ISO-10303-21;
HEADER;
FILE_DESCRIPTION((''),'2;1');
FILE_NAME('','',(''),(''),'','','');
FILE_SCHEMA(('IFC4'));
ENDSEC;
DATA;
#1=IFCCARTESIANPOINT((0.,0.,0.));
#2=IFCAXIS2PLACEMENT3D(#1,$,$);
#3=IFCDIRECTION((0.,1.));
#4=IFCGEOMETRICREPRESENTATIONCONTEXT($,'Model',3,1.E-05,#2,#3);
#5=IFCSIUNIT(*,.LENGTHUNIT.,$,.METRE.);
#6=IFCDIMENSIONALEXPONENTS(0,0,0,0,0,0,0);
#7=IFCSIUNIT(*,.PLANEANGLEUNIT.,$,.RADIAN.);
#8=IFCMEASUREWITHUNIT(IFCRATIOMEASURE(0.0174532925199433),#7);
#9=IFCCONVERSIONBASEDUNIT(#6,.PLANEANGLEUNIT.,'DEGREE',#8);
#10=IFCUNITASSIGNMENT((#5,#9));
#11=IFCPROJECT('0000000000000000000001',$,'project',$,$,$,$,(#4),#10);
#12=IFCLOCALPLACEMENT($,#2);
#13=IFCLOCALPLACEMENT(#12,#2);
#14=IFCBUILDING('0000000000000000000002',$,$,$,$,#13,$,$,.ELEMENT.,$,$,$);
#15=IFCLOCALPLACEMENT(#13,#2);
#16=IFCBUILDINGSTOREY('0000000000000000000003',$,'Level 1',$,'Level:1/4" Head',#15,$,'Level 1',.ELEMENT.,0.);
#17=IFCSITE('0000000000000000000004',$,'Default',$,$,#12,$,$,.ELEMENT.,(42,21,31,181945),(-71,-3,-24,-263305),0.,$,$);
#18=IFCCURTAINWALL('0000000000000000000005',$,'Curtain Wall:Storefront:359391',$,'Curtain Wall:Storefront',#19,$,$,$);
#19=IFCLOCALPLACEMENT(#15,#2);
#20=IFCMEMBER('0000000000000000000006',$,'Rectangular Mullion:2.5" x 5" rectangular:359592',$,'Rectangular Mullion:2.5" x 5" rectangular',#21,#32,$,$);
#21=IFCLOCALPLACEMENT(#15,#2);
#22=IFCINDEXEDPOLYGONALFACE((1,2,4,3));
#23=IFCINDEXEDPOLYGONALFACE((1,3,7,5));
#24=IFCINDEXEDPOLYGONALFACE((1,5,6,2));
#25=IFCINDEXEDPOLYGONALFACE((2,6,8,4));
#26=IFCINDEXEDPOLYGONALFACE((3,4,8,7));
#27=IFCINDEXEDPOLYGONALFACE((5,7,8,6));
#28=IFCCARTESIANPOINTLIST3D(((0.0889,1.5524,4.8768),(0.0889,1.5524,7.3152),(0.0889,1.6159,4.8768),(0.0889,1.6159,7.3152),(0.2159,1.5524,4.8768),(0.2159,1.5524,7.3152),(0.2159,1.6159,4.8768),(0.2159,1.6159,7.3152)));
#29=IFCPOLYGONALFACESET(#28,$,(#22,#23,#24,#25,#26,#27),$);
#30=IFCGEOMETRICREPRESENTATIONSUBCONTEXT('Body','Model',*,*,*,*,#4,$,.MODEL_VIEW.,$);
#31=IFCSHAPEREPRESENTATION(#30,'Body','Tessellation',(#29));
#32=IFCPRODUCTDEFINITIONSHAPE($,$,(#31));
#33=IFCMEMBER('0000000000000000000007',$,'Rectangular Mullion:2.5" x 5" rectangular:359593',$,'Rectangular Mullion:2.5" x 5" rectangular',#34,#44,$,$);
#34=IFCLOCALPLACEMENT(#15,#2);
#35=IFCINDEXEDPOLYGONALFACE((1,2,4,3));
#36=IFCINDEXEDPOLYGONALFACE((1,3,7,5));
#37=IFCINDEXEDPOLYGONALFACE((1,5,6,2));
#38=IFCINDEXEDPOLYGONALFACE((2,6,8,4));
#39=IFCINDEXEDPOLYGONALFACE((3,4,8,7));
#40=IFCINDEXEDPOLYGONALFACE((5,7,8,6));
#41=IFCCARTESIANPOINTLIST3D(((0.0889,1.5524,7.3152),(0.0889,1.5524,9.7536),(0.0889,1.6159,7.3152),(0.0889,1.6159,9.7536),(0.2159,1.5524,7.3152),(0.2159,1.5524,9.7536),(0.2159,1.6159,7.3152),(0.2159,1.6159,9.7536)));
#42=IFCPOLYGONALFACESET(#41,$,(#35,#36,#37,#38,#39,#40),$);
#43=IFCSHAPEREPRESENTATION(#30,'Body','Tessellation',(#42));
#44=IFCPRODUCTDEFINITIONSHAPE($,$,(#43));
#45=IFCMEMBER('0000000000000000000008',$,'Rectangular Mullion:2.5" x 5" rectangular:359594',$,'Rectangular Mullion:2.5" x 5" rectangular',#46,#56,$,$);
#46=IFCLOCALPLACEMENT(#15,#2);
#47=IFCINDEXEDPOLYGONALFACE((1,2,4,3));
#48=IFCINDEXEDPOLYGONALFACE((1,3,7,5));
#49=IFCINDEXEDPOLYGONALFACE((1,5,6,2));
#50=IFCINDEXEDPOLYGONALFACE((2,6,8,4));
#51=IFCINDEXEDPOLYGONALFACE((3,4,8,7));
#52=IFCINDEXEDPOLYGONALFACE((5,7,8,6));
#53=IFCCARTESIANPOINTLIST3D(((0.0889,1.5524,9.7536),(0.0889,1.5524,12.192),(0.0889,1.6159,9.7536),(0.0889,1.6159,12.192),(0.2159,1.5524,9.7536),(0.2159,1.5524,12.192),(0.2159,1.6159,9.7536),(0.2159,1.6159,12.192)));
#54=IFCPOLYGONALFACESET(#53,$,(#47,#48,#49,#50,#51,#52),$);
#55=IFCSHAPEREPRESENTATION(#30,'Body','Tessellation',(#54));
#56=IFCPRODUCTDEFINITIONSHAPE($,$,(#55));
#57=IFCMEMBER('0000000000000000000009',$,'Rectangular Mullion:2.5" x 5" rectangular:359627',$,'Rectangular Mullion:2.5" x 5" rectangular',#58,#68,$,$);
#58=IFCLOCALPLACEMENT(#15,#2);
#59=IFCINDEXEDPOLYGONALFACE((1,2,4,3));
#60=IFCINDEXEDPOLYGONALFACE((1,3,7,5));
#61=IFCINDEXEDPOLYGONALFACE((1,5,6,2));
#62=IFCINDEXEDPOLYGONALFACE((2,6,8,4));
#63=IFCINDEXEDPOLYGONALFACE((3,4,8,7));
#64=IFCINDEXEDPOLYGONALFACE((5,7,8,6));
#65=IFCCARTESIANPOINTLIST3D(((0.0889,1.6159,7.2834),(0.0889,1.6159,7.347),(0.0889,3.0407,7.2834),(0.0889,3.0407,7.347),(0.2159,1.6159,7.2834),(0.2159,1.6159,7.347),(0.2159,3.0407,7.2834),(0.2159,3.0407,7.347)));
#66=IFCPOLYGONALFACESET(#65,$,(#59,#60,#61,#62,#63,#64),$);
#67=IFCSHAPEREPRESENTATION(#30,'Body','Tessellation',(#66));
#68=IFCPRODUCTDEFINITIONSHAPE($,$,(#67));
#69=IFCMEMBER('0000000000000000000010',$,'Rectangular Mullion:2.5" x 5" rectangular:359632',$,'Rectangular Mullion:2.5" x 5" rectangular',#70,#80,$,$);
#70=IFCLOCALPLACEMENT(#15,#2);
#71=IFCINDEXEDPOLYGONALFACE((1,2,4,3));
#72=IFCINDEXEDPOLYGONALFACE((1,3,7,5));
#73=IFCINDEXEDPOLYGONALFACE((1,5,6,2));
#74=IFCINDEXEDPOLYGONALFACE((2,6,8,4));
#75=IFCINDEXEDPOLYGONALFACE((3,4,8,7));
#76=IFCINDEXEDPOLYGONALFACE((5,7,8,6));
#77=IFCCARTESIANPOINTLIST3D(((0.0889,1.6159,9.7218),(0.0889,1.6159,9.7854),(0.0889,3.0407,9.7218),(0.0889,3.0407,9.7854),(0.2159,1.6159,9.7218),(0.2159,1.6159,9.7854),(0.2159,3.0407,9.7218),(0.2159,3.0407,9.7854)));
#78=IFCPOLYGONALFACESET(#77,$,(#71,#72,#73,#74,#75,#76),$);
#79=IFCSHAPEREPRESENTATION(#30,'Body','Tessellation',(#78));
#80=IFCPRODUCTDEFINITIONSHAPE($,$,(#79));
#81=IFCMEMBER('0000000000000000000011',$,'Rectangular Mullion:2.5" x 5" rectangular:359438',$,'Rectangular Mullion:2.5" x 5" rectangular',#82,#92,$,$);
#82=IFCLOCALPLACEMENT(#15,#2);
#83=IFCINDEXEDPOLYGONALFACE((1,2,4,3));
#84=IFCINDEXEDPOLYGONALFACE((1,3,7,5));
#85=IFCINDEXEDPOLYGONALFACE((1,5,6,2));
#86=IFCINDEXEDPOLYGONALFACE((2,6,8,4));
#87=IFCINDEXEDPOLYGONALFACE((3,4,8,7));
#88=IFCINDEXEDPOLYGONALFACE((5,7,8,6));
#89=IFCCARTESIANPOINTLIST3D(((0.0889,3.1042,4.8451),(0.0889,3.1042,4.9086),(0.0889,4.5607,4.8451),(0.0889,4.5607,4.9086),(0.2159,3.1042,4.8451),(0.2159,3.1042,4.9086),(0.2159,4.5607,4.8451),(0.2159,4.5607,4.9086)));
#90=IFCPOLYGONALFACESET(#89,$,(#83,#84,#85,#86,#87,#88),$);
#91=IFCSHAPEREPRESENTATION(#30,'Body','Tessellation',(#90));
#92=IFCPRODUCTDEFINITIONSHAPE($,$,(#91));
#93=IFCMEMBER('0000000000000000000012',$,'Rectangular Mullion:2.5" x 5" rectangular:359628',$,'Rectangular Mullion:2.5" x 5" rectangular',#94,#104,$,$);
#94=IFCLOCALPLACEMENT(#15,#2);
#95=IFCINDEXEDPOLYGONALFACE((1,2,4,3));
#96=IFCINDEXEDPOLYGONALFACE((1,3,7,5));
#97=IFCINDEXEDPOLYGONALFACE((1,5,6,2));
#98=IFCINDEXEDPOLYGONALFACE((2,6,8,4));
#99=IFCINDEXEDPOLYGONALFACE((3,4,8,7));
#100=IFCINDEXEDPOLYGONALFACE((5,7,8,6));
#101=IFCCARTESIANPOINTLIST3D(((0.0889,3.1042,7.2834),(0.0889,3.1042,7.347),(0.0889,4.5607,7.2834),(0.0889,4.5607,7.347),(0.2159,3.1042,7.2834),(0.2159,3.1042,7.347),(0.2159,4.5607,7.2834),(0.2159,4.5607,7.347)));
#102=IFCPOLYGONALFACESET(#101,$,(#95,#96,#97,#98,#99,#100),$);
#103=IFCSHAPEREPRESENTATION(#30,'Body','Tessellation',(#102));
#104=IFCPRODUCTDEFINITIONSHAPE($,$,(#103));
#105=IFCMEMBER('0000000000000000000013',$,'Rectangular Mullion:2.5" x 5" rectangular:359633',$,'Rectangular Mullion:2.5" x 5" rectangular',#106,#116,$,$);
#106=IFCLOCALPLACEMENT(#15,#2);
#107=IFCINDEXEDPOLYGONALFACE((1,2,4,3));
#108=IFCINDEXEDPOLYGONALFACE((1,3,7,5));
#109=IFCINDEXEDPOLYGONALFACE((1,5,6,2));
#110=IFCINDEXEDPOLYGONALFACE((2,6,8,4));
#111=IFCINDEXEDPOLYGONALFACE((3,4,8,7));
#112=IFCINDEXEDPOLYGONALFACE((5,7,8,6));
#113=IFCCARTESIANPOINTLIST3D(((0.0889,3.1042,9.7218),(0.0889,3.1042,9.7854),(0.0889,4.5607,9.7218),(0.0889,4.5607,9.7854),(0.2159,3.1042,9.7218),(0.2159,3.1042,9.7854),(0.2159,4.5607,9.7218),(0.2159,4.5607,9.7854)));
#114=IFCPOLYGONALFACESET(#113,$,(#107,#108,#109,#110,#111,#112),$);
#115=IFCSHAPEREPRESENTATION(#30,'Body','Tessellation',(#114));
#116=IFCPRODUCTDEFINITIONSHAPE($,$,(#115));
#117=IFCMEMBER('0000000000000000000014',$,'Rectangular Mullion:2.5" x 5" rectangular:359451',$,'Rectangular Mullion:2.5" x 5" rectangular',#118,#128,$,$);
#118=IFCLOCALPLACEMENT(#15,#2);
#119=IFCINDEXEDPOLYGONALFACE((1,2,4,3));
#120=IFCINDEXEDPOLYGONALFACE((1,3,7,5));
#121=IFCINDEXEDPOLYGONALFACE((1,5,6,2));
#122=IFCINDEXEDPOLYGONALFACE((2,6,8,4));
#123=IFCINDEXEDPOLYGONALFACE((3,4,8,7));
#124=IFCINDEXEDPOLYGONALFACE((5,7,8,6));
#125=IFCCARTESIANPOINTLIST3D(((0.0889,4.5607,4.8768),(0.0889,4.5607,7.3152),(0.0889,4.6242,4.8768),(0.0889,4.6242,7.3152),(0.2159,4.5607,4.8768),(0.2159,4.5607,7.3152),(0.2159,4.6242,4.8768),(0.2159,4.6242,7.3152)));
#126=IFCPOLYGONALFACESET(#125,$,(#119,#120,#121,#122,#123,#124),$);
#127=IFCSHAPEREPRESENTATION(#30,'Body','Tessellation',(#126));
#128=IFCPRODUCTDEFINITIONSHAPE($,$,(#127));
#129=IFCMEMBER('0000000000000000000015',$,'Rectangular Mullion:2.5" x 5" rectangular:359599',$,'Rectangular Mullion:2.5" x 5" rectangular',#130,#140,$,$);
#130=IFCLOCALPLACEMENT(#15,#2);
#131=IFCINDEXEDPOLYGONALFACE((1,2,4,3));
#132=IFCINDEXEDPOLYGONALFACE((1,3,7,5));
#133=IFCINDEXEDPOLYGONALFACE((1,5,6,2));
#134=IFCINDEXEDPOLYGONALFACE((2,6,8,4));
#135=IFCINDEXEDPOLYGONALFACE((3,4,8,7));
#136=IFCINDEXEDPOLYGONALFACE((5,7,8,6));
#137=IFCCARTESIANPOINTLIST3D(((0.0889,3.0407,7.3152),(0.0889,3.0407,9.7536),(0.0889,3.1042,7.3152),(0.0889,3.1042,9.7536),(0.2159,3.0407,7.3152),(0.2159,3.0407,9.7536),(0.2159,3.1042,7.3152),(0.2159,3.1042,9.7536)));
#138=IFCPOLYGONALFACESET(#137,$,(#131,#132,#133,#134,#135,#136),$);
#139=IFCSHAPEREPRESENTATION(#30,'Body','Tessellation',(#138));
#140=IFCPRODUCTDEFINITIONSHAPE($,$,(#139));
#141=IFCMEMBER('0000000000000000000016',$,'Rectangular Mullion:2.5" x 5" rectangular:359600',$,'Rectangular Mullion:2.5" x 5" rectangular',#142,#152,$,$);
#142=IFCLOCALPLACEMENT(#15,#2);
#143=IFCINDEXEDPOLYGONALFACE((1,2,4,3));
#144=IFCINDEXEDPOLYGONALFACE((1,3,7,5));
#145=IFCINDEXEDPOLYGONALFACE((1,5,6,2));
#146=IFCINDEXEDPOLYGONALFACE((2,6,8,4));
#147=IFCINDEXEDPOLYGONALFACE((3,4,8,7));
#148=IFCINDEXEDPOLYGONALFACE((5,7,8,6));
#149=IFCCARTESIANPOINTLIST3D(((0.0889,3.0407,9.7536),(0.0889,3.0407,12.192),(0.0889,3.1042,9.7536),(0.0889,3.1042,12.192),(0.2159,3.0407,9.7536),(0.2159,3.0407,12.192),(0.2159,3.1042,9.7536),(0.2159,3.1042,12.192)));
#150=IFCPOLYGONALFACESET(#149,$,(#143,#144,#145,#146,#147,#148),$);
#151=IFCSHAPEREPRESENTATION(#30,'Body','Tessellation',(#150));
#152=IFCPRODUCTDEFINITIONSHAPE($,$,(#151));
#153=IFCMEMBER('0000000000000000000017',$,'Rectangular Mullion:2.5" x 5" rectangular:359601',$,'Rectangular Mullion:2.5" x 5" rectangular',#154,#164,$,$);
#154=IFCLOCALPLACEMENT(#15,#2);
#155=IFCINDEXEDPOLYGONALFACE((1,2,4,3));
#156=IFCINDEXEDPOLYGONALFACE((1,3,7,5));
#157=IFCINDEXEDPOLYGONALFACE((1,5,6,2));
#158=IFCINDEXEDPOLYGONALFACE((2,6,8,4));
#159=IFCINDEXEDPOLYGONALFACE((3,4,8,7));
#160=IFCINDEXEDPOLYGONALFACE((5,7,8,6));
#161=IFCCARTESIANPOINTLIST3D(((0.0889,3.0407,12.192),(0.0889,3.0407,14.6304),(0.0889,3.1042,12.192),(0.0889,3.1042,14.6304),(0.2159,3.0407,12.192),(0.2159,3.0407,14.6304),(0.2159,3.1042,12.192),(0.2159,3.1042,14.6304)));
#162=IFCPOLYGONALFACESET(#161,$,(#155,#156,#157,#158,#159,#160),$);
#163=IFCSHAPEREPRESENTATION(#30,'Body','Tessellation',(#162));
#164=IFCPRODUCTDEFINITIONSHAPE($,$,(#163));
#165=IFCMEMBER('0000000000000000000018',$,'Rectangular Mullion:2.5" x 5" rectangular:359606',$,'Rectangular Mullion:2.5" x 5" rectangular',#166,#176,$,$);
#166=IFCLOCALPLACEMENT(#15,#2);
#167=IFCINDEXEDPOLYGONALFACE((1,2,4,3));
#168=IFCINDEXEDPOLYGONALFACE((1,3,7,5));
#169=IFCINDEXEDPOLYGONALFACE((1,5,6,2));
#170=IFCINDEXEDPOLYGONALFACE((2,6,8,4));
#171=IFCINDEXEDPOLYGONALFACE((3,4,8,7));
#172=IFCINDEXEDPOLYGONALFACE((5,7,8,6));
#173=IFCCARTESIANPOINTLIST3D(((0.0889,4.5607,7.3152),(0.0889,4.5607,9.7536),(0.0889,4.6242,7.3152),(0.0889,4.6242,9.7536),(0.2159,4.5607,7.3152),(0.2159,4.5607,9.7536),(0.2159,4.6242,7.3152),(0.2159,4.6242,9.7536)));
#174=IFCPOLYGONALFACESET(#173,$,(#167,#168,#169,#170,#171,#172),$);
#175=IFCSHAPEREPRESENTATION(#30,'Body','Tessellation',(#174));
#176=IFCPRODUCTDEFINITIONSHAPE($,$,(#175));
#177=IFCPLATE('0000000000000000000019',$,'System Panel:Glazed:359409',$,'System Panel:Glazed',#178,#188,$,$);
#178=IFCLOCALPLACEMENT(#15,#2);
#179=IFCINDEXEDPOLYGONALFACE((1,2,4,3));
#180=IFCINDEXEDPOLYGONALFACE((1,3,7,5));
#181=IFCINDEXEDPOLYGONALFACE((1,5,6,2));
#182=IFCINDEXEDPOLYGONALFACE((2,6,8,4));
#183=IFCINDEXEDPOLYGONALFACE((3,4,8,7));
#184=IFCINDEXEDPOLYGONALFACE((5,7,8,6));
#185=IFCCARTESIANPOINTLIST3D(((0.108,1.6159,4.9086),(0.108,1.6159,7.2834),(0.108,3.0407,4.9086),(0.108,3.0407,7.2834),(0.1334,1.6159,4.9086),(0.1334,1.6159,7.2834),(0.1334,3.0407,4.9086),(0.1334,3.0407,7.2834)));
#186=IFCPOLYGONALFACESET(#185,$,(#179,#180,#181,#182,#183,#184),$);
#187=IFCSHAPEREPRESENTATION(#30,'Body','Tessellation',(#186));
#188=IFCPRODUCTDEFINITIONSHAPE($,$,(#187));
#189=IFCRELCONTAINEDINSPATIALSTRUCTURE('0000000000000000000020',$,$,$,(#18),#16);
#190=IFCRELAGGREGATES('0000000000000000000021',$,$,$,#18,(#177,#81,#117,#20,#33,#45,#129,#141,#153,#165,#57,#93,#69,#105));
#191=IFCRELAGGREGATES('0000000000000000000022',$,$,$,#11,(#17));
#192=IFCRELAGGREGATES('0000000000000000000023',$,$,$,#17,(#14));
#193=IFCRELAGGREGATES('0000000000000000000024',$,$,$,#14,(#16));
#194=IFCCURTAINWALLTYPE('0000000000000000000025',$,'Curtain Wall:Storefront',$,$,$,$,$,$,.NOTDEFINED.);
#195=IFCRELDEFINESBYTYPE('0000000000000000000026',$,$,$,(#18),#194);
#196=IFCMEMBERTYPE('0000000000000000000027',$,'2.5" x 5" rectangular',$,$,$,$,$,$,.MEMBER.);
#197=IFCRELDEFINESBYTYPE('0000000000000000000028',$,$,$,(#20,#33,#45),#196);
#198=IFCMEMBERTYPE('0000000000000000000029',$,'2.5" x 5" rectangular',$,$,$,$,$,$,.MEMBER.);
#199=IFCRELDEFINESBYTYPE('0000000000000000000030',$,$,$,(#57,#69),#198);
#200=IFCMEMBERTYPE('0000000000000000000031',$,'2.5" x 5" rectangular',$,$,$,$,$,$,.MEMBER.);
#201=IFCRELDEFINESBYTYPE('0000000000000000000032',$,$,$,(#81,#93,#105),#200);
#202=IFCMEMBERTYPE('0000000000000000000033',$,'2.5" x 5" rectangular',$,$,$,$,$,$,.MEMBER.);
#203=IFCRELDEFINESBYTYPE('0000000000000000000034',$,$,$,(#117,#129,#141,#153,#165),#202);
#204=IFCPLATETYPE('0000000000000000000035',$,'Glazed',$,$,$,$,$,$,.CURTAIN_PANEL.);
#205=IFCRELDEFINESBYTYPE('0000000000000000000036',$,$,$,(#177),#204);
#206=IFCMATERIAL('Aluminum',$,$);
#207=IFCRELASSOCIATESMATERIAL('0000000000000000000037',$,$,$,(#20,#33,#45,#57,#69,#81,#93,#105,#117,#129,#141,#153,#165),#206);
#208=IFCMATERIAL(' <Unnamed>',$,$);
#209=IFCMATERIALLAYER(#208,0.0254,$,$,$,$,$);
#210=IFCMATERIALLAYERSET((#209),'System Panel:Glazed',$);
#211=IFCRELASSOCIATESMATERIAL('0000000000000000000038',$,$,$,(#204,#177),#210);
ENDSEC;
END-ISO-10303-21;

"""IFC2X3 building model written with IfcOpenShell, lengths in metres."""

from ifc_helpers import new_model, entity, si_unit, converted_unit, direction, frame, frame_2d, origin, origin_2d_with_axis, place, context, subcontext, project, spatial, rectangle, extrude, source, transform, mapped, material, layer, layer_set, layer_usage, type_object, type_shapes, element, aggregate, save


model = new_model("IFC2X3")

# Units and contexts
model_context = context("Model", 3, precision=1e-05, world=origin(), true_north=direction((0.0, 1.0)))
body_context = subcontext(model_context, "Body", "Model", "MODEL_VIEW")
ifc_project = project(units=[si_unit("LENGTHUNIT", "METRE"), converted_unit("PLANEANGLEUNIT", "DEGREE", entity("IfcRatioMeasure", 0.0174532925199433), si_unit("PLANEANGLEUNIT", "RADIAN"), dimensions=[0, 0, 0, 0, 0, 0, 0])], contexts=[model_context])

# Site, building, storey
site_placement = place(None, origin())
site = spatial("IfcSite", under=ifc_project, at=site_placement, Name="Default", CompositionType="ELEMENT", RefLatitude=(42, 21, 31, 181945), RefLongitude=(-71, -3, -24, -263305), RefElevation=0.0)
building_placement = place(site_placement, origin())
building = spatial("IfcBuilding", under=site, at=building_placement, CompositionType="ELEMENT")
storey_placement = place(building_placement, origin())
storey = spatial("IfcBuildingStorey", under=building, at=storey_placement, Name="Level 1", ObjectType="Level:1/4\" Head", LongName="Level 1", CompositionType="ELEMENT", Elevation=0.0)

# Curtain wall, members, plate
curtain_wall_type = type_object("IfcCurtainWallType", Name="Curtain Wall:Storefront", PredefinedType="NOTDEFINED")
curtain_wall_placement = place(storey_placement, origin())
curtain_wall = element("IfcCurtainWall", 1, at=curtain_wall_placement, inside=storey, type_object=curtain_wall_type, Name="Curtain Wall:Storefront:359391", ObjectType="Curtain Wall:Storefront")
ifc_material_1 = material(Name="Aluminum")
member_type_1 = type_object("IfcMemberType", Name="2.5\" x 5\" rectangular", PredefinedType="MEMBER")
shared_shape_1 = source(origin(), body_context, "Body", "SweptSolid", [
    extrude(rectangle(XDim=0.127, YDim=0.0635, at=origin_2d_with_axis()), frame((-0.0318, 0.0, -2.4384), z_axis=(0.0, 0.0, 1.0), x_axis=(0.0, -1.0, 0.0)), (0.0, 0.0, 1.0), 2.4384),
])
type_shapes(member_type_1, [shared_shape_1])
member_1_placement = place(storey_placement, frame((0.1524, 1.5524, 7.3152), z_axis=(0.0, 0.0, 1.0), x_axis=(0.0, -1.0, 0.0)))
member_1 = element("IfcMember", 2, at=member_1_placement, type_object=member_type_1, material=ifc_material_1, Name="Rectangular Mullion:2.5\" x 5\" rectangular:359592", ObjectType="Rectangular Mullion:2.5\" x 5\" rectangular", context=body_context, shape_type="MappedRepresentation", body=[
    mapped(shared_shape_1, transform((0.0, 0.0, 0.0), scale=1.0)),
])
member_2_placement = place(storey_placement, frame((0.1524, 1.5524, 9.7536), z_axis=(0.0, 0.0, 1.0), x_axis=(0.0, -1.0, 0.0)))
member_2 = element("IfcMember", 3, at=member_2_placement, type_object=member_type_1, material=ifc_material_1, Name="Rectangular Mullion:2.5\" x 5\" rectangular:359593", ObjectType="Rectangular Mullion:2.5\" x 5\" rectangular", context=body_context, shape_type="MappedRepresentation", body=[
    mapped(shared_shape_1, transform((0.0, 0.0, 0.0), scale=1.0)),
])
member_3_placement = place(storey_placement, frame((0.1524, 1.5524, 12.192), z_axis=(0.0, 0.0, 1.0), x_axis=(0.0, -1.0, 0.0)))
member_3 = element("IfcMember", 4, at=member_3_placement, type_object=member_type_1, material=ifc_material_1, Name="Rectangular Mullion:2.5\" x 5\" rectangular:359594", ObjectType="Rectangular Mullion:2.5\" x 5\" rectangular", context=body_context, shape_type="MappedRepresentation", body=[
    mapped(shared_shape_1, transform((0.0, 0.0, 0.0), scale=1.0)),
])
member_type_2 = type_object("IfcMemberType", Name="2.5\" x 5\" rectangular", PredefinedType="MEMBER")
shared_shape_2 = source(origin(), body_context, "Body", "SweptSolid", [
    extrude(rectangle(XDim=0.127, YDim=0.0635, at=origin_2d_with_axis()), frame((0.0, 0.0, -1.4248), z_axis=(0.0, 0.0, 1.0), x_axis=(0.0, -1.0, 0.0)), (0.0, 0.0, 1.0), 1.4248),
])
type_shapes(member_type_2, [shared_shape_2])
member_4_placement = place(storey_placement, frame((0.1524, 3.0407, 7.3152), z_axis=(0.0, 1.0, 0.0), x_axis=(0.0, 0.0, 1.0)))
member_4 = element("IfcMember", 5, at=member_4_placement, type_object=member_type_2, material=ifc_material_1, Name="Rectangular Mullion:2.5\" x 5\" rectangular:359627", ObjectType="Rectangular Mullion:2.5\" x 5\" rectangular", context=body_context, shape_type="MappedRepresentation", body=[
    mapped(shared_shape_2, transform((0.0, 0.0, 0.0), scale=1.0)),
])
member_5_placement = place(storey_placement, frame((0.1524, 3.0407, 9.7536), z_axis=(0.0, 1.0, 0.0), x_axis=(0.0, 0.0, 1.0)))
member_5 = element("IfcMember", 6, at=member_5_placement, type_object=member_type_2, material=ifc_material_1, Name="Rectangular Mullion:2.5\" x 5\" rectangular:359632", ObjectType="Rectangular Mullion:2.5\" x 5\" rectangular", context=body_context, shape_type="MappedRepresentation", body=[
    mapped(shared_shape_2, transform((0.0, 0.0, 0.0), scale=1.0)),
])
member_type_3 = type_object("IfcMemberType", Name="2.5\" x 5\" rectangular", PredefinedType="MEMBER")
shared_shape_3 = source(origin(), body_context, "Body", "SweptSolid", [
    extrude(rectangle(XDim=0.127, YDim=0.0635, at=origin_2d_with_axis()), frame((0.0, 0.0, -1.4565), z_axis=(0.0, 0.0, 1.0), x_axis=(0.0, -1.0, 0.0)), (0.0, 0.0, 1.0), 1.4565),
])
type_shapes(member_type_3, [shared_shape_3])
member_6_placement = place(storey_placement, frame((0.1524, 4.5607, 4.8768), z_axis=(0.0, 1.0, 0.0), x_axis=(0.0, 0.0, 1.0)))
member_6 = element("IfcMember", 7, at=member_6_placement, type_object=member_type_3, material=ifc_material_1, Name="Rectangular Mullion:2.5\" x 5\" rectangular:359438", ObjectType="Rectangular Mullion:2.5\" x 5\" rectangular", context=body_context, shape_type="MappedRepresentation", body=[
    mapped(shared_shape_3, transform((0.0, 0.0, 0.0), scale=1.0)),
])
member_7_placement = place(storey_placement, frame((0.1524, 4.5607, 7.3152), z_axis=(0.0, 1.0, 0.0), x_axis=(0.0, 0.0, 1.0)))
member_7 = element("IfcMember", 8, at=member_7_placement, type_object=member_type_3, material=ifc_material_1, Name="Rectangular Mullion:2.5\" x 5\" rectangular:359628", ObjectType="Rectangular Mullion:2.5\" x 5\" rectangular", context=body_context, shape_type="MappedRepresentation", body=[
    mapped(shared_shape_3, transform((0.0, 0.0, 0.0), scale=1.0)),
])
member_8_placement = place(storey_placement, frame((0.1524, 4.5607, 9.7536), z_axis=(0.0, 1.0, 0.0), x_axis=(0.0, 0.0, 1.0)))
member_8 = element("IfcMember", 9, at=member_8_placement, type_object=member_type_3, material=ifc_material_1, Name="Rectangular Mullion:2.5\" x 5\" rectangular:359633", ObjectType="Rectangular Mullion:2.5\" x 5\" rectangular", context=body_context, shape_type="MappedRepresentation", body=[
    mapped(shared_shape_3, transform((0.0, 0.0, 0.0), scale=1.0)),
])
member_type_4 = type_object("IfcMemberType", Name="2.5\" x 5\" rectangular", PredefinedType="MEMBER")
shared_shape_4 = source(origin(), body_context, "Body", "SweptSolid", [
    extrude(rectangle(XDim=0.127, YDim=0.0635, at=origin_2d_with_axis()), frame((0.0, 0.0, -2.4384), z_axis=(0.0, 0.0, 1.0), x_axis=(0.0, -1.0, 0.0)), (0.0, 0.0, 1.0), 2.4384),
])
type_shapes(member_type_4, [shared_shape_4])
member_9_placement = place(storey_placement, frame((0.1524, 4.5924, 4.8768), z_axis=(0.0, 0.0, -1.0), x_axis=(0.0, 1.0, 0.0)))
member_9 = element("IfcMember", 10, at=member_9_placement, type_object=member_type_4, material=ifc_material_1, Name="Rectangular Mullion:2.5\" x 5\" rectangular:359451", ObjectType="Rectangular Mullion:2.5\" x 5\" rectangular", context=body_context, shape_type="MappedRepresentation", body=[
    mapped(shared_shape_4, transform((0.0, 0.0, 0.0), scale=1.0)),
])
member_10_placement = place(storey_placement, frame((0.1524, 3.0724, 7.3152), z_axis=(0.0, 0.0, -1.0), x_axis=(0.0, 1.0, 0.0)))
member_10 = element("IfcMember", 11, at=member_10_placement, type_object=member_type_4, material=ifc_material_1, Name="Rectangular Mullion:2.5\" x 5\" rectangular:359599", ObjectType="Rectangular Mullion:2.5\" x 5\" rectangular", context=body_context, shape_type="MappedRepresentation", body=[
    mapped(shared_shape_4, transform((0.0, 0.0, 0.0), scale=1.0)),
])
member_11_placement = place(storey_placement, frame((0.1524, 3.0724, 9.7536), z_axis=(0.0, 0.0, -1.0), x_axis=(0.0, 1.0, 0.0)))
member_11 = element("IfcMember", 12, at=member_11_placement, type_object=member_type_4, material=ifc_material_1, Name="Rectangular Mullion:2.5\" x 5\" rectangular:359600", ObjectType="Rectangular Mullion:2.5\" x 5\" rectangular", context=body_context, shape_type="MappedRepresentation", body=[
    mapped(shared_shape_4, transform((0.0, 0.0, 0.0), scale=1.0)),
])
member_12_placement = place(storey_placement, frame((0.1524, 3.0724, 12.192), z_axis=(0.0, 0.0, -1.0), x_axis=(0.0, 1.0, 0.0)))
member_12 = element("IfcMember", 13, at=member_12_placement, type_object=member_type_4, material=ifc_material_1, Name="Rectangular Mullion:2.5\" x 5\" rectangular:359601", ObjectType="Rectangular Mullion:2.5\" x 5\" rectangular", context=body_context, shape_type="MappedRepresentation", body=[
    mapped(shared_shape_4, transform((0.0, 0.0, 0.0), scale=1.0)),
])
member_13_placement = place(storey_placement, frame((0.1524, 4.5924, 7.3152), z_axis=(0.0, 0.0, -1.0), x_axis=(0.0, 1.0, 0.0)))
member_13 = element("IfcMember", 14, at=member_13_placement, type_object=member_type_4, material=ifc_material_1, Name="Rectangular Mullion:2.5\" x 5\" rectangular:359606", ObjectType="Rectangular Mullion:2.5\" x 5\" rectangular", context=body_context, shape_type="MappedRepresentation", body=[
    mapped(shared_shape_4, transform((0.0, 0.0, 0.0), scale=1.0)),
])
ifc_material_2 = material(Name=" <Unnamed>")
ifc_layer = layer(ifc_material_2, 0.0254)
ifc_layer_set = layer_set([ifc_layer], Name="System Panel:Glazed")
ifc_layer_usage_1 = layer_usage(ifc_layer_set, "AXIS3", "POSITIVE", 0.1042)
plate_type_1 = type_object("IfcPlateType", Name="Glazed", PredefinedType="CURTAIN_PANEL", material=ifc_layer_set)
shared_shape_5 = source(origin(), body_context, "Body", "SweptSolid", [
    extrude(rectangle(XDim=0.0254, YDim=1.4248, at=frame_2d((0.0, 0.0), x_axis=(1.0, 0.0))), frame((0.7124, 0.0127, 0.0), z_axis=(0.0, 0.0, 1.0), x_axis=(0.0, 1.0, 0.0)), (0.0, 0.0, 1.0), 2.3749),
])
type_shapes(plate_type_1, [shared_shape_5])
plate_1_placement = place(curtain_wall_placement, frame((0.1334, 1.6159, 4.9085), z_axis=(0.0, 0.0, 1.0), x_axis=(0.0, 1.0, 0.0)))
plate_1 = element("IfcPlate", 15, at=plate_1_placement, type_object=plate_type_1, material=ifc_layer_usage_1, Name="System Panel:Glazed:359409", ObjectType="System Panel:Glazed", context=body_context, shape_type="MappedRepresentation", body=[
    mapped(shared_shape_5, transform((0.0, 0.0, 0.0), scale=1.0)),
])
aggregate(curtain_wall, [plate_1, member_6, member_9, member_1, member_2, member_3, member_10, member_11, member_12, member_13, member_4, member_7, member_5, member_8])

save(model, "model.ifc")
